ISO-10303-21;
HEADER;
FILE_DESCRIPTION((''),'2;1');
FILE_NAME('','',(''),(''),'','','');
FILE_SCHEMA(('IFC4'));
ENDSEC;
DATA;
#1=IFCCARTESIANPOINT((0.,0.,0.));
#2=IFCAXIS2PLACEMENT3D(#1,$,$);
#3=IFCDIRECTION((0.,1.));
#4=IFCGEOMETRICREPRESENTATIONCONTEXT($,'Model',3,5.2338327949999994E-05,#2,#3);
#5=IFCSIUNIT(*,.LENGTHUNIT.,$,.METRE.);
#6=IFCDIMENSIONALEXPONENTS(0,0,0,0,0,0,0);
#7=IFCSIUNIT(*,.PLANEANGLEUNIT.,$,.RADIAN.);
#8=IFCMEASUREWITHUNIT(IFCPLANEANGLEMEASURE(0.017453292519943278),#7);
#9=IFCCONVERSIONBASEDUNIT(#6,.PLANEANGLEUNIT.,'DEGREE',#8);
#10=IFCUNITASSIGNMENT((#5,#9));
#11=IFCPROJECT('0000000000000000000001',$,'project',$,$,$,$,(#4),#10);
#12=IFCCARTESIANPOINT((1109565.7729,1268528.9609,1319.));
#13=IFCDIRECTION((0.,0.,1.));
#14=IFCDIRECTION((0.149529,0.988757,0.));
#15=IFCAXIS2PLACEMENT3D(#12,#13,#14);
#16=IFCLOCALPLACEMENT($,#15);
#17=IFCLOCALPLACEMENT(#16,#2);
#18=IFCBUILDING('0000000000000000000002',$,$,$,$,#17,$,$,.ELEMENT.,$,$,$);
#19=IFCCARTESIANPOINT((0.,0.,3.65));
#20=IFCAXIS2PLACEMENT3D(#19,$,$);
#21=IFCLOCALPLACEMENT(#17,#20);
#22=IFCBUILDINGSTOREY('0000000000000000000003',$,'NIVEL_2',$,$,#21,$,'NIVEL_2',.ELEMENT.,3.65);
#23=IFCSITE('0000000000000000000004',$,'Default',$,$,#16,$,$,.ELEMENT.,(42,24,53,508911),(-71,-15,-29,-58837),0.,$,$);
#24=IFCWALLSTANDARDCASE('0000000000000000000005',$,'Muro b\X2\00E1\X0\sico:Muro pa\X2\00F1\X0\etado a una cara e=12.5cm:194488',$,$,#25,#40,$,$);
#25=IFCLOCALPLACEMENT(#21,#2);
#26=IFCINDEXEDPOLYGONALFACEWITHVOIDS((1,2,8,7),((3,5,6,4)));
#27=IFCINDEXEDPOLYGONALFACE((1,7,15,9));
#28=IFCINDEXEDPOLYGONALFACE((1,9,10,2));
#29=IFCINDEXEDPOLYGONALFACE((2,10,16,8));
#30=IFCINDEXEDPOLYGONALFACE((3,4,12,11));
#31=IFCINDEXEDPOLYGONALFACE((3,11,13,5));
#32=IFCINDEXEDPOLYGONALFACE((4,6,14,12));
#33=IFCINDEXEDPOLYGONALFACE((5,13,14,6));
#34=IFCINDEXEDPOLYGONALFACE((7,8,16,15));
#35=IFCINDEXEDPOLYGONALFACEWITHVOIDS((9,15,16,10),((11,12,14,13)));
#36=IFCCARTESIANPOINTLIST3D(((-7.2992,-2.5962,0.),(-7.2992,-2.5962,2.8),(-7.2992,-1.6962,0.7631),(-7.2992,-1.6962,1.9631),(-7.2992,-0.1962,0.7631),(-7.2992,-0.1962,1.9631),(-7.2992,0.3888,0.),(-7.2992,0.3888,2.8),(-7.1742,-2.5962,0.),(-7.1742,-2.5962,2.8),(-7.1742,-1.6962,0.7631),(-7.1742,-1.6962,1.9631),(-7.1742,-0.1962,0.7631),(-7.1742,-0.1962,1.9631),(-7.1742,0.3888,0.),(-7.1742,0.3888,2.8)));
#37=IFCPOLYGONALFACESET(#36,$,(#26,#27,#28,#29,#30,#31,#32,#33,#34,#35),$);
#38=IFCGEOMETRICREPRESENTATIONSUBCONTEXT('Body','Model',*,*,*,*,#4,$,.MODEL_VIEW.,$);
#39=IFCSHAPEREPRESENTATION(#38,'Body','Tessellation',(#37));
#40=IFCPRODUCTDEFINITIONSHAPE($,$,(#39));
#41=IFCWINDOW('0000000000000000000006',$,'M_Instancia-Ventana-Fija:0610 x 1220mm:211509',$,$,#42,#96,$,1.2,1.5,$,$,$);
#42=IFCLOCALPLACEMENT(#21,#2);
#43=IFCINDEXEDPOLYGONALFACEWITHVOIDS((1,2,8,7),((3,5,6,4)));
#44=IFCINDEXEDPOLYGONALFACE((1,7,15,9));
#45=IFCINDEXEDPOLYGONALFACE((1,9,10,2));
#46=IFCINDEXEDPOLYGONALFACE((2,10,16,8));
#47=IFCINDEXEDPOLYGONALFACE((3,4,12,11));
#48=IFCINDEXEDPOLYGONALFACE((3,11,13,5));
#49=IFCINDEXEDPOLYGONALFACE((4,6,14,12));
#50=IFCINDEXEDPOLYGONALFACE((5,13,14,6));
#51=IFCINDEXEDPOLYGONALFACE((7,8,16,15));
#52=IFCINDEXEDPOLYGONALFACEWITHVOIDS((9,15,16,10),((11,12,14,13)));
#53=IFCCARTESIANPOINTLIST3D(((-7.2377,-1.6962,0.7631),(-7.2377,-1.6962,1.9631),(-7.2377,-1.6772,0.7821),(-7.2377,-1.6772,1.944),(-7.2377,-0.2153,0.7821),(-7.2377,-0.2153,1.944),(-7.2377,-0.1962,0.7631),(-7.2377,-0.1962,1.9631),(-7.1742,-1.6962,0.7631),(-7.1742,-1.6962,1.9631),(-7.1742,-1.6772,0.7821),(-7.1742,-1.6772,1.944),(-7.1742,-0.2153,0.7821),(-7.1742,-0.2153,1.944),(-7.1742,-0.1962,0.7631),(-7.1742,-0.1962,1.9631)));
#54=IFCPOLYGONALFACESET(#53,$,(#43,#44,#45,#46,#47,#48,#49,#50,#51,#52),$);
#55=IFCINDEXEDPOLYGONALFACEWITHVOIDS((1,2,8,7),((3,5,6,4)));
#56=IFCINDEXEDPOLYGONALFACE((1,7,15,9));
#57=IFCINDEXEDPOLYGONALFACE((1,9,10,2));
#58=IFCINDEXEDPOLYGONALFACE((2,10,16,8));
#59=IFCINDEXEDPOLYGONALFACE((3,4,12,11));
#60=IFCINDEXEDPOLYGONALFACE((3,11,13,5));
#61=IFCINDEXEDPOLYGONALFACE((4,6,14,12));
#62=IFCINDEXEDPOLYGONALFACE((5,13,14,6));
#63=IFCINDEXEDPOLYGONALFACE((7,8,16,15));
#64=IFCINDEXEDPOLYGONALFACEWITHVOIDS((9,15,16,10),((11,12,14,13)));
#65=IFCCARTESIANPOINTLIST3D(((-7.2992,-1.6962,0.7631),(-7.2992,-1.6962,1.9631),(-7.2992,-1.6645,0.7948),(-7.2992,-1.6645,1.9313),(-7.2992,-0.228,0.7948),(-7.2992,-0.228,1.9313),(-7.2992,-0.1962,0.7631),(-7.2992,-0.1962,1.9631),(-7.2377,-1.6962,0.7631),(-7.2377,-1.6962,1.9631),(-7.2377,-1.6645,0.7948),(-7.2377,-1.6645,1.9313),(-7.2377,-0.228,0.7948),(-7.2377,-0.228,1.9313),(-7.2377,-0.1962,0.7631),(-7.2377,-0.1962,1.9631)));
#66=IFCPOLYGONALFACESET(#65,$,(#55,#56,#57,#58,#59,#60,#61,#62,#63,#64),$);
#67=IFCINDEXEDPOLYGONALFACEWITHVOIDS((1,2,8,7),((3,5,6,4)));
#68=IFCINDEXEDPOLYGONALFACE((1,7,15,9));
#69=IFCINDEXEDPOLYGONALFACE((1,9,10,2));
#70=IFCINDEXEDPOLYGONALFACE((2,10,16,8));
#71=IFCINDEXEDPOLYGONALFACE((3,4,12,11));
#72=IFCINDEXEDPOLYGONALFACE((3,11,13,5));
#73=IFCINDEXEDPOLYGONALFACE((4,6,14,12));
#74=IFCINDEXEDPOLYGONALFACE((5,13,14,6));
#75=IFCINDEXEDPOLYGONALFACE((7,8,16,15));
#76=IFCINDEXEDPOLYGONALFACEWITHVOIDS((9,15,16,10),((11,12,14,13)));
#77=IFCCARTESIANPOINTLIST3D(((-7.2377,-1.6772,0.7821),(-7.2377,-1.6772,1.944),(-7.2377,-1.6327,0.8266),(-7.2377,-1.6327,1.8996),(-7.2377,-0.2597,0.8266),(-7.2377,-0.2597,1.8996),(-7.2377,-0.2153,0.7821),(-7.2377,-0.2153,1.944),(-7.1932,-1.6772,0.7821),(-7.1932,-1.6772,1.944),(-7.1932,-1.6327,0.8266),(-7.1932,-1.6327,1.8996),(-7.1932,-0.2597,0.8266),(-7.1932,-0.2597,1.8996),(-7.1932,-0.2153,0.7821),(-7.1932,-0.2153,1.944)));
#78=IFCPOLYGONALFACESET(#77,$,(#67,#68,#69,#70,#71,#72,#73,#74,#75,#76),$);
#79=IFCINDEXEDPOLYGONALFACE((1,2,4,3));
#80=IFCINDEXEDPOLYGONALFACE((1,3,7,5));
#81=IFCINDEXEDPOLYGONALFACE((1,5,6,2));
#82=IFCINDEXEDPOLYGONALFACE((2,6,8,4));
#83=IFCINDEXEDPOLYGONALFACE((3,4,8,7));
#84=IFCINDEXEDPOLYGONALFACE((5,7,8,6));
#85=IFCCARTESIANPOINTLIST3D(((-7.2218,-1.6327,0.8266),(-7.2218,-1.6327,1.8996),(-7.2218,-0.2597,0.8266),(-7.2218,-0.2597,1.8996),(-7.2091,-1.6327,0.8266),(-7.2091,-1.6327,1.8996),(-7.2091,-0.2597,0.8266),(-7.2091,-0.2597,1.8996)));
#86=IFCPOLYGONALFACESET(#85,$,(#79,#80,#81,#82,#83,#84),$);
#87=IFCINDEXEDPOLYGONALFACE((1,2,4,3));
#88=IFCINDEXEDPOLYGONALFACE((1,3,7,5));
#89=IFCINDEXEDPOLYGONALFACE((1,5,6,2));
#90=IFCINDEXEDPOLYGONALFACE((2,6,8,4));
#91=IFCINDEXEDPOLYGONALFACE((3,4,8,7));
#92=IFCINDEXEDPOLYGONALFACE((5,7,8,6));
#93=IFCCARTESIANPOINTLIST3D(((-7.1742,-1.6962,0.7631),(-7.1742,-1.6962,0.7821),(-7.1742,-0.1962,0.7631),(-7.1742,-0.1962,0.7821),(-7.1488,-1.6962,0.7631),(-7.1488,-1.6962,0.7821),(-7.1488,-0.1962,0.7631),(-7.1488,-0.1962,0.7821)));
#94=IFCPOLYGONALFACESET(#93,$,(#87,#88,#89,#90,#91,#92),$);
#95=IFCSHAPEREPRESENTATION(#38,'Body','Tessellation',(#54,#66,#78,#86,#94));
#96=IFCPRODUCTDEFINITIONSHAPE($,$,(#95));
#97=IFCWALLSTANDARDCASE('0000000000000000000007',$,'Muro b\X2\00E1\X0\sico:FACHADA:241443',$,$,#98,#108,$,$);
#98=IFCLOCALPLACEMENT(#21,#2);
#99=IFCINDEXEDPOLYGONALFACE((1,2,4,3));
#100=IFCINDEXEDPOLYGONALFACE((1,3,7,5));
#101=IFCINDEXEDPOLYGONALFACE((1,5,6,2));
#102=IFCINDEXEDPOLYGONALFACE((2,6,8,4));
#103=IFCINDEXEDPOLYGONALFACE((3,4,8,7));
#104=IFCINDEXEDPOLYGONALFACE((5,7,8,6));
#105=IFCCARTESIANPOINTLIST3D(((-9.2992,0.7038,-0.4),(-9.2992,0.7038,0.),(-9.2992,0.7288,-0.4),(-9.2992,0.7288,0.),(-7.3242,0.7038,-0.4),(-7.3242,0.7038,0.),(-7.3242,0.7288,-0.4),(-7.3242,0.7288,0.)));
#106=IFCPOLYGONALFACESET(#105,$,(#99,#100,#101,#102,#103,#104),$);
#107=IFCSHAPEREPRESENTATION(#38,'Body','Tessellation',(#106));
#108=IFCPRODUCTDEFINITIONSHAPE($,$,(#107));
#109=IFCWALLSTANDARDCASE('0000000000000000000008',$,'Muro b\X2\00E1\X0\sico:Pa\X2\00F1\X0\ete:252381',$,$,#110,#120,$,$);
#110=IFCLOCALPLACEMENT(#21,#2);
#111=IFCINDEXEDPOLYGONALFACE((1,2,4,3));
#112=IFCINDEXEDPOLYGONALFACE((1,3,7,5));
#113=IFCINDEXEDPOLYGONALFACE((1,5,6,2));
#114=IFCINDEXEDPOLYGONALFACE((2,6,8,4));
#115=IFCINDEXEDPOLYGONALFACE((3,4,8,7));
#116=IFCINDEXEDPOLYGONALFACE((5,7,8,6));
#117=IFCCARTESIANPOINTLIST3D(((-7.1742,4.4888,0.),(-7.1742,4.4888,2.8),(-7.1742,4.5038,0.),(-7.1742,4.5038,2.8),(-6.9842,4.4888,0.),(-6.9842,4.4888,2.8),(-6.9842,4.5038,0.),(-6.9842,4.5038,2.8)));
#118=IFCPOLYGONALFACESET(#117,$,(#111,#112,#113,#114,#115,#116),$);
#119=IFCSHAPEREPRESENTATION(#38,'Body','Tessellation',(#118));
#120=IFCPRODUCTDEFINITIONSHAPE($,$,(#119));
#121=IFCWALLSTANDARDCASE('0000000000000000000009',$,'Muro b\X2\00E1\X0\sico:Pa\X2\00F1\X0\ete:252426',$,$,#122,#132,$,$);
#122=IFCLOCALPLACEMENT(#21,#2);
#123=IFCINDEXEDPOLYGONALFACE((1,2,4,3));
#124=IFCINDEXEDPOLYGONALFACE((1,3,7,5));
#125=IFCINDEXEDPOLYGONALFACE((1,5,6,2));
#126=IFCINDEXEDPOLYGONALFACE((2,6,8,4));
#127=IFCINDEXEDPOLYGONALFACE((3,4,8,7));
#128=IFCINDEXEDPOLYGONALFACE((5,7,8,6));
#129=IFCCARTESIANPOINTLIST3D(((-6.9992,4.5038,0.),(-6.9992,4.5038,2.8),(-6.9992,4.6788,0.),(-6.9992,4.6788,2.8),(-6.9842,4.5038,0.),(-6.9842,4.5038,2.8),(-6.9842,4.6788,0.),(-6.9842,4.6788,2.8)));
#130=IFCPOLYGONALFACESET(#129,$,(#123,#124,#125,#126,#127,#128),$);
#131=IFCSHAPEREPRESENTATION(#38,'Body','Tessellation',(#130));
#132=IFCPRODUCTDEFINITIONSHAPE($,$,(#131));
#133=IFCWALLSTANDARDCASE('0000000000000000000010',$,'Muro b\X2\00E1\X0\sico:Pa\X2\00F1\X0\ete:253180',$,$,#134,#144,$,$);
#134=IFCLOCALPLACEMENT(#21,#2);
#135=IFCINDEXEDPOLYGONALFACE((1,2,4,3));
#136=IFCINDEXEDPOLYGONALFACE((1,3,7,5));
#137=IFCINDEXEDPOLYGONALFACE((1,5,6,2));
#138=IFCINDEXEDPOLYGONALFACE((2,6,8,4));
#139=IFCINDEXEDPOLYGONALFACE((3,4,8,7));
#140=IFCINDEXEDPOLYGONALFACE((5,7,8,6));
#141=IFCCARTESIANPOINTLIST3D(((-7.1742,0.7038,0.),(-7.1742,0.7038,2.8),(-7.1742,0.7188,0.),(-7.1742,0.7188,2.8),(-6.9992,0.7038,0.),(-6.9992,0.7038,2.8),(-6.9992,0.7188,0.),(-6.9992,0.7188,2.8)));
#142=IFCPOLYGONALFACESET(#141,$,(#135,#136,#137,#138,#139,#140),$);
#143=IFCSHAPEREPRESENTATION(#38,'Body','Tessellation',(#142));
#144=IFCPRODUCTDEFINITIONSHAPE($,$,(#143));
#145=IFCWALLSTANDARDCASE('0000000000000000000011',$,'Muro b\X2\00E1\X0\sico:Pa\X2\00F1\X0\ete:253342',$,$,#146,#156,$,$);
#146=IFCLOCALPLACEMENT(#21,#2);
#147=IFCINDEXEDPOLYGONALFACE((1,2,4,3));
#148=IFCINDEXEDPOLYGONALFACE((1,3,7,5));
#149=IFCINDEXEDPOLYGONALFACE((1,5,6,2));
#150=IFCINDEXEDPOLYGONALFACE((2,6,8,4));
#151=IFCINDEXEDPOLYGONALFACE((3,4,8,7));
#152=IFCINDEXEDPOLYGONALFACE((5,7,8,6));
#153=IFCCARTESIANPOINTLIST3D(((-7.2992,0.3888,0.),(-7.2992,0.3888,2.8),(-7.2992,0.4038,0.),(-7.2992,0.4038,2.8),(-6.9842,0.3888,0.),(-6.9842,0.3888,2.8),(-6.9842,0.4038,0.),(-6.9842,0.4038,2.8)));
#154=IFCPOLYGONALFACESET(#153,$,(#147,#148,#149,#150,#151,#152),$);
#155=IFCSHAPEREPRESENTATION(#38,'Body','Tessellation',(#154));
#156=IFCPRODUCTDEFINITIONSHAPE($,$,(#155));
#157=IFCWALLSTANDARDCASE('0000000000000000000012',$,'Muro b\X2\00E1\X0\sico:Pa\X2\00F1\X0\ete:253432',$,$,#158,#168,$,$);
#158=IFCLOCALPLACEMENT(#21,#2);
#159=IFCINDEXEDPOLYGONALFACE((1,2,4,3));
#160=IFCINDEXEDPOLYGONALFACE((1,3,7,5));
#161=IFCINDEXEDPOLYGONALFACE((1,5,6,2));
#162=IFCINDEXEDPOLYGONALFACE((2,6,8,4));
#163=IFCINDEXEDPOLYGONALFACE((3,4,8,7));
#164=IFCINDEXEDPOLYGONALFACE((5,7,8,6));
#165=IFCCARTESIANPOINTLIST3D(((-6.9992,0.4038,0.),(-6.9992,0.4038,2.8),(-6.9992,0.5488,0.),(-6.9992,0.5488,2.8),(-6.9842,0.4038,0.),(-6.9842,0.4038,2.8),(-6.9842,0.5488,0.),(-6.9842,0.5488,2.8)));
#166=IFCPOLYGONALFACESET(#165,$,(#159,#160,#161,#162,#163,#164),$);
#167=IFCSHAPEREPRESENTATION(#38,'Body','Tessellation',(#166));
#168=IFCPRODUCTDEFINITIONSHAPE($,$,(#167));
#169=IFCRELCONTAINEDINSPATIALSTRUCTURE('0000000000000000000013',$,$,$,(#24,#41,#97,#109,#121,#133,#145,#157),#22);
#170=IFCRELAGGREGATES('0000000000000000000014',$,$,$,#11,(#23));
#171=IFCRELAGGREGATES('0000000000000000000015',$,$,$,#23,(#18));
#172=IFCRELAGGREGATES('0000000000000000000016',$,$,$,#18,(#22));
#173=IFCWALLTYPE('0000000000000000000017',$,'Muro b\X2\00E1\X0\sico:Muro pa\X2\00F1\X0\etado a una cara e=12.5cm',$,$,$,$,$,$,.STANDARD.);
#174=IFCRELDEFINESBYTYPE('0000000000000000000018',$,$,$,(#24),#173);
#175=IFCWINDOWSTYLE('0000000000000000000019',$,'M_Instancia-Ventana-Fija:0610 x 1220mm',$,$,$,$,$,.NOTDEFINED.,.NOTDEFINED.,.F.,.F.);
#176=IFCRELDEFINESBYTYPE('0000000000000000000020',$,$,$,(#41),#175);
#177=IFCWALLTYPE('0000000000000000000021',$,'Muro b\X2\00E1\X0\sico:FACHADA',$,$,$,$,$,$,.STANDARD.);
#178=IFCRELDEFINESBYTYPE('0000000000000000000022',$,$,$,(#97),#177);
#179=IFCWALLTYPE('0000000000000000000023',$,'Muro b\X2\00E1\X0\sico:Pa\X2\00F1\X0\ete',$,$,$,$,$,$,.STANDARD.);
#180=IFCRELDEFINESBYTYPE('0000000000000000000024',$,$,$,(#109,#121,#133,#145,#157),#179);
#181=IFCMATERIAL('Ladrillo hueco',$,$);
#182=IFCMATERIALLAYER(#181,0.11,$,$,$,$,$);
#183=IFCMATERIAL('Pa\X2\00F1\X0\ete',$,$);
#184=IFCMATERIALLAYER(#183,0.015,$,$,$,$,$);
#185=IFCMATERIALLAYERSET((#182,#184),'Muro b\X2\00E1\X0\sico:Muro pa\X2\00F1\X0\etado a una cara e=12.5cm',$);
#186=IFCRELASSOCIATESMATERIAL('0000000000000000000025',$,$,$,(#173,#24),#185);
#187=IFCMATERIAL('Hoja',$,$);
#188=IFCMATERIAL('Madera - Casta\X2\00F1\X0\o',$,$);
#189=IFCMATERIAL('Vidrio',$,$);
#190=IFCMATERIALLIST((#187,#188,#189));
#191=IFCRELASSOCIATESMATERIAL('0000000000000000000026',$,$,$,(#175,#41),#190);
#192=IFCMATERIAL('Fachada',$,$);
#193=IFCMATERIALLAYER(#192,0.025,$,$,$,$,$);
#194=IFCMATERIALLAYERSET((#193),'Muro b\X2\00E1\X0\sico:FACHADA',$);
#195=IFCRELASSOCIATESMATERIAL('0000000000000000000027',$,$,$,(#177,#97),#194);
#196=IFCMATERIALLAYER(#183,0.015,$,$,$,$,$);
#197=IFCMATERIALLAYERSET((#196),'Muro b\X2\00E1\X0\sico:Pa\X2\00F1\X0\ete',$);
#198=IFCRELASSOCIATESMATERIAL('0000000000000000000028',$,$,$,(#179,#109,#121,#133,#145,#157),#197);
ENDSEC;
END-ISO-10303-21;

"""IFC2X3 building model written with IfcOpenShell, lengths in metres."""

from ifc_helpers import new_model, entity, si_unit, converted_unit, direction, frame, frame_2d, origin, origin_2d_with_axis, place, context, subcontext, project, spatial, polyline, rectangle, outline, extrude, source, transform, mapped, material, material_list, layer, layer_set, layer_usage, type_object, type_shapes, element, fill, save


model = new_model("IFC2X3")

# Units and contexts
model_context = context("Model", 3, precision=5.2338327949999994e-05, world=origin(), true_north=direction((0.0, 1.0)))
body_context = subcontext(model_context, "Body", "Model", "MODEL_VIEW")
ifc_project = project(units=[si_unit("LENGTHUNIT", "METRE"), converted_unit("PLANEANGLEUNIT", "DEGREE", entity("IfcPlaneAngleMeasure", 0.017453292519943278), si_unit("PLANEANGLEUNIT", "RADIAN"), dimensions=[0, 0, 0, 0, 0, 0, 0])], contexts=[model_context])

# Site, building, storey
site_placement = place(None, frame((1109565.7729, 1268528.9609, 1319.0), z_axis=(0.0, 0.0, 1.0), x_axis=(0.149529, 0.988757, 0.0)))
site = spatial("IfcSite", under=ifc_project, at=site_placement, Name="Default", CompositionType="ELEMENT", RefLatitude=(42, 24, 53, 508911), RefLongitude=(-71, -15, -29, -58837), RefElevation=0.0)
building_placement = place(site_placement, origin())
building = spatial("IfcBuilding", under=site, at=building_placement, CompositionType="ELEMENT")
storey_placement = place(building_placement, frame((0.0, 0.0, 3.65)))
storey = spatial("IfcBuildingStorey", under=building, at=storey_placement, Name="NIVEL_2", LongName="NIVEL_2", CompositionType="ELEMENT", Elevation=3.65)

# Shared definitions
ifc_material_1 = material(Name="Pañete")
ifc_material_2 = material(Name="Ladrillo hueco")

# Shared definitions
ifc_layer_1 = layer(ifc_material_2, 0.11)
ifc_layer_2 = layer(ifc_material_1, 0.015)
ifc_layer_set_1 = layer_set([ifc_layer_1, ifc_layer_2], Name="Muro básico:Muro pañetado a una cara e=12.5cm")
wall_type_1 = type_object("IfcWallType", Name="Muro básico:Muro pañetado a una cara e=12.5cm", PredefinedType="STANDARD", material=ifc_layer_set_1)
ifc_material_3 = material(Name="Hoja")
ifc_material_4 = material(Name="Madera - Castaño")
ifc_material_5 = material(Name="Vidrio")
ifc_material_list = material_list([ifc_material_3, ifc_material_4, ifc_material_5])

# Wall, opening, window
ifc_layer_usage_1 = layer_usage(ifc_layer_set_1, "AXIS2", "POSITIVE", -0.0625)
wall_1_placement = place(storey_placement, frame((-7.2367, 0.3888, 0.0), z_axis=(0.0, 0.0, 1.0), x_axis=(0.0, -1.0, 0.0)))
wall_1 = element("IfcWallStandardCase", 1, at=wall_1_placement, inside=storey, type_object=wall_type_1, material=ifc_layer_usage_1, Name="Muro básico:Muro pañetado a una cara e=12.5cm:194488", context=body_context, shape_type="SweptSolid", body=[
    extrude(rectangle(XDim=2.985, YDim=0.125, at=frame_2d((1.4925, 0.0), x_axis=(-1.0, 0.0))), origin(), (0.0, 0.0, 1.0), 2.8),
])
opening_1_placement = place(wall_1_placement, frame((0.585, -0.0625, 0.7631)))
opening_1 = element("IfcOpeningElement", 2, at=opening_1_placement, cuts=wall_1, ObjectType="Opening", context=body_context, shape_type="SweptSolid", body=[
    extrude(rectangle(XDim=1.2, YDim=1.5, at=frame_2d((0.6, 0.75), x_axis=(-1.0, 0.0))), frame((0.0, 0.0, 0.0), z_axis=(0.0, 1.0, 0.0), x_axis=(0.0, 0.0, 1.0)), (0.0, 0.0, 1.0), 0.125),
])
window_style_1 = type_object("IfcWindowStyle", Name="M_Instancia-Ventana-Fija:0610 x 1220mm", ConstructionType="NOTDEFINED", OperationType="NOTDEFINED", ParameterTakesPrecedence=False, Sizeable=False, material=ifc_material_list)
shared_shape_1 = source(origin(), body_context, "Body", "SweptSolid", [
    extrude(outline(polyline([(-0.6, -0.75), (0.6, -0.75), (0.6, 0.75), (-0.6, 0.75), (-0.6, -0.75)]), holes=[polyline([(-0.5809, -0.731), (-0.5809, 0.731), (0.581, 0.731), (0.581, -0.731), (-0.5809, -0.731)])]), frame((0.75, 0.0616, 0.6), z_axis=(0.0, 1.0, 0.0), x_axis=(0.0, 0.0, -1.0)), (0.0, 0.0, 1.0), 0.0635),
    extrude(outline(polyline([(-0.75, -0.6), (0.75, -0.6), (0.75, 0.6), (-0.75, 0.6), (-0.75, -0.6)]), holes=[polyline([(-0.7183, -0.5682), (-0.7183, 0.5683), (0.7183, 0.5683), (0.7183, -0.5682), (-0.7183, -0.5682)])]), frame((0.75, 0.0, 0.6), z_axis=(0.0, 1.0, 0.0), x_axis=(1.0, 0.0, 0.0)), (0.0, 0.0, 1.0), 0.0616),
    extrude(outline(polyline([(-0.731, -0.581), (0.731, -0.581), (0.731, 0.581), (-0.731, 0.581), (-0.731, -0.581)]), holes=[polyline([(-0.6865, -0.5365), (-0.6865, 0.5365), (0.6865, 0.5365), (0.6865, -0.5365), (-0.6865, -0.5365)])]), frame((0.75, 0.0616, 0.6), z_axis=(0.0, 1.0, 0.0), x_axis=(1.0, 0.0, 0.0)), (0.0, 0.0, 1.0), 0.0444),
    extrude(rectangle(XDim=0.0127, YDim=1.373, at=origin_2d_with_axis()), frame((0.75, 0.0838, 0.0635), z_axis=(0.0, 0.0, 1.0), x_axis=(0.0, 1.0, 0.0)), (0.0, 0.0, 1.0), 1.073),
    extrude(rectangle(XDim=0.0254, YDim=1.5, at=origin_2d_with_axis()), frame((0.75, 0.1377, 0.0), z_axis=(0.0, 0.0, 1.0), x_axis=(0.0, -1.0, 0.0)), (0.0, 0.0, 1.0), 0.019),
])
type_shapes(window_style_1, [shared_shape_1])
window_1_placement = place(opening_1_placement, origin())
window_1 = element("IfcWindow", 3, at=window_1_placement, inside=storey, type_object=window_style_1, material=ifc_material_list, Name="M_Instancia-Ventana-Fija:0610 x 1220mm:211509", OverallHeight=1.2, OverallWidth=1.5, context=body_context, shape_type="MappedRepresentation", body=[
    mapped(shared_shape_1, transform((0.0, 0.0, 0.0), scale=1.0)),
])
fill(opening_1, window_1)

# Walls
ifc_material_6 = material(Name="Fachada")
ifc_layer_3 = layer(ifc_material_6, 0.025)
ifc_layer_set_2 = layer_set([ifc_layer_3], Name="Muro básico:FACHADA")
ifc_layer_usage_2 = layer_usage(ifc_layer_set_2, "AXIS2", "NEGATIVE", 0.0125)
wall_type_2 = type_object("IfcWallType", Name="Muro básico:FACHADA", PredefinedType="STANDARD", material=ifc_layer_set_2)
wall_2_placement = place(storey_placement, frame((-9.2992, 0.7163, -0.4)))
element("IfcWallStandardCase", 4, at=wall_2_placement, inside=storey, type_object=wall_type_2, material=ifc_layer_usage_2, Name="Muro básico:FACHADA:241443", context=body_context, shape_type="SweptSolid", body=[
    extrude(rectangle(XDim=1.975, YDim=0.025, at=frame_2d((0.9875, 0.0), x_axis=(-1.0, 0.0))), origin(), (0.0, 0.0, 1.0), 0.4),
])
ifc_layer_4 = layer(ifc_material_1, 0.015)
ifc_layer_set_3 = layer_set([ifc_layer_4], Name="Muro básico:Pañete")
ifc_layer_usage_3 = layer_usage(ifc_layer_set_3, "AXIS2", "POSITIVE", -0.0075)
wall_type_3 = type_object("IfcWallType", Name="Muro básico:Pañete", PredefinedType="STANDARD", material=ifc_layer_set_3)
wall_3_placement = place(storey_placement, frame((-7.1742, 4.4963, 0.0)))
element("IfcWallStandardCase", 5, at=wall_3_placement, inside=storey, type_object=wall_type_3, material=ifc_layer_usage_3, Name="Muro básico:Pañete:252381", context=body_context, shape_type="SweptSolid", body=[
    extrude(rectangle(XDim=0.19, YDim=0.015, at=frame_2d((0.095, 0.0), x_axis=(-1.0, 0.0))), origin(), (0.0, 0.0, 1.0), 2.8),
])
ifc_layer_usage_4 = layer_usage(ifc_layer_set_3, "AXIS2", "POSITIVE", -0.0075)
wall_4_placement = place(storey_placement, frame((-6.9917, 4.5038, 0.0), z_axis=(0.0, 0.0, 1.0), x_axis=(0.0, 1.0, 0.0)))
element("IfcWallStandardCase", 6, at=wall_4_placement, inside=storey, type_object=wall_type_3, material=ifc_layer_usage_4, Name="Muro básico:Pañete:252426", context=body_context, shape_type="SweptSolid", body=[
    extrude(rectangle(XDim=0.175, YDim=0.015, at=frame_2d((0.0875, 0.0), x_axis=(-1.0, 0.0))), origin(), (0.0, 0.0, 1.0), 2.8),
])
ifc_layer_usage_5 = layer_usage(ifc_layer_set_3, "AXIS2", "NEGATIVE", 0.0075)
wall_5_placement = place(storey_placement, frame((-7.1742, 0.7113, 0.0)))
element("IfcWallStandardCase", 7, at=wall_5_placement, inside=storey, type_object=wall_type_3, material=ifc_layer_usage_5, Name="Muro básico:Pañete:253180", context=body_context, shape_type="SweptSolid", body=[
    extrude(rectangle(XDim=0.175, YDim=0.015, at=frame_2d((0.0875, 0.0), x_axis=(-1.0, 0.0))), origin(), (0.0, 0.0, 1.0), 2.8),
])
ifc_layer_usage_6 = layer_usage(ifc_layer_set_3, "AXIS2", "POSITIVE", -0.0075)
wall_6_placement = place(storey_placement, frame((-7.2992, 0.3963, 0.0)))
element("IfcWallStandardCase", 8, at=wall_6_placement, inside=storey, type_object=wall_type_3, material=ifc_layer_usage_6, Name="Muro básico:Pañete:253342", context=body_context, shape_type="SweptSolid", body=[
    extrude(rectangle(XDim=0.315, YDim=0.015, at=frame_2d((0.1575, 0.0), x_axis=(-1.0, 0.0))), origin(), (0.0, 0.0, 1.0), 2.8),
])
ifc_layer_usage_7 = layer_usage(ifc_layer_set_3, "AXIS2", "POSITIVE", -0.0075)
wall_7_placement = place(storey_placement, frame((-6.9917, 0.4038, 0.0), z_axis=(0.0, 0.0, 1.0), x_axis=(0.0, 1.0, 0.0)))
element("IfcWallStandardCase", 9, at=wall_7_placement, inside=storey, type_object=wall_type_3, material=ifc_layer_usage_7, Name="Muro básico:Pañete:253432", context=body_context, shape_type="SweptSolid", body=[
    extrude(rectangle(XDim=0.145, YDim=0.015, at=frame_2d((0.0725, 0.0), x_axis=(-1.0, 0.0))), origin(), (0.0, 0.0, 1.0), 2.8),
])

save(model, "model.ifc")
